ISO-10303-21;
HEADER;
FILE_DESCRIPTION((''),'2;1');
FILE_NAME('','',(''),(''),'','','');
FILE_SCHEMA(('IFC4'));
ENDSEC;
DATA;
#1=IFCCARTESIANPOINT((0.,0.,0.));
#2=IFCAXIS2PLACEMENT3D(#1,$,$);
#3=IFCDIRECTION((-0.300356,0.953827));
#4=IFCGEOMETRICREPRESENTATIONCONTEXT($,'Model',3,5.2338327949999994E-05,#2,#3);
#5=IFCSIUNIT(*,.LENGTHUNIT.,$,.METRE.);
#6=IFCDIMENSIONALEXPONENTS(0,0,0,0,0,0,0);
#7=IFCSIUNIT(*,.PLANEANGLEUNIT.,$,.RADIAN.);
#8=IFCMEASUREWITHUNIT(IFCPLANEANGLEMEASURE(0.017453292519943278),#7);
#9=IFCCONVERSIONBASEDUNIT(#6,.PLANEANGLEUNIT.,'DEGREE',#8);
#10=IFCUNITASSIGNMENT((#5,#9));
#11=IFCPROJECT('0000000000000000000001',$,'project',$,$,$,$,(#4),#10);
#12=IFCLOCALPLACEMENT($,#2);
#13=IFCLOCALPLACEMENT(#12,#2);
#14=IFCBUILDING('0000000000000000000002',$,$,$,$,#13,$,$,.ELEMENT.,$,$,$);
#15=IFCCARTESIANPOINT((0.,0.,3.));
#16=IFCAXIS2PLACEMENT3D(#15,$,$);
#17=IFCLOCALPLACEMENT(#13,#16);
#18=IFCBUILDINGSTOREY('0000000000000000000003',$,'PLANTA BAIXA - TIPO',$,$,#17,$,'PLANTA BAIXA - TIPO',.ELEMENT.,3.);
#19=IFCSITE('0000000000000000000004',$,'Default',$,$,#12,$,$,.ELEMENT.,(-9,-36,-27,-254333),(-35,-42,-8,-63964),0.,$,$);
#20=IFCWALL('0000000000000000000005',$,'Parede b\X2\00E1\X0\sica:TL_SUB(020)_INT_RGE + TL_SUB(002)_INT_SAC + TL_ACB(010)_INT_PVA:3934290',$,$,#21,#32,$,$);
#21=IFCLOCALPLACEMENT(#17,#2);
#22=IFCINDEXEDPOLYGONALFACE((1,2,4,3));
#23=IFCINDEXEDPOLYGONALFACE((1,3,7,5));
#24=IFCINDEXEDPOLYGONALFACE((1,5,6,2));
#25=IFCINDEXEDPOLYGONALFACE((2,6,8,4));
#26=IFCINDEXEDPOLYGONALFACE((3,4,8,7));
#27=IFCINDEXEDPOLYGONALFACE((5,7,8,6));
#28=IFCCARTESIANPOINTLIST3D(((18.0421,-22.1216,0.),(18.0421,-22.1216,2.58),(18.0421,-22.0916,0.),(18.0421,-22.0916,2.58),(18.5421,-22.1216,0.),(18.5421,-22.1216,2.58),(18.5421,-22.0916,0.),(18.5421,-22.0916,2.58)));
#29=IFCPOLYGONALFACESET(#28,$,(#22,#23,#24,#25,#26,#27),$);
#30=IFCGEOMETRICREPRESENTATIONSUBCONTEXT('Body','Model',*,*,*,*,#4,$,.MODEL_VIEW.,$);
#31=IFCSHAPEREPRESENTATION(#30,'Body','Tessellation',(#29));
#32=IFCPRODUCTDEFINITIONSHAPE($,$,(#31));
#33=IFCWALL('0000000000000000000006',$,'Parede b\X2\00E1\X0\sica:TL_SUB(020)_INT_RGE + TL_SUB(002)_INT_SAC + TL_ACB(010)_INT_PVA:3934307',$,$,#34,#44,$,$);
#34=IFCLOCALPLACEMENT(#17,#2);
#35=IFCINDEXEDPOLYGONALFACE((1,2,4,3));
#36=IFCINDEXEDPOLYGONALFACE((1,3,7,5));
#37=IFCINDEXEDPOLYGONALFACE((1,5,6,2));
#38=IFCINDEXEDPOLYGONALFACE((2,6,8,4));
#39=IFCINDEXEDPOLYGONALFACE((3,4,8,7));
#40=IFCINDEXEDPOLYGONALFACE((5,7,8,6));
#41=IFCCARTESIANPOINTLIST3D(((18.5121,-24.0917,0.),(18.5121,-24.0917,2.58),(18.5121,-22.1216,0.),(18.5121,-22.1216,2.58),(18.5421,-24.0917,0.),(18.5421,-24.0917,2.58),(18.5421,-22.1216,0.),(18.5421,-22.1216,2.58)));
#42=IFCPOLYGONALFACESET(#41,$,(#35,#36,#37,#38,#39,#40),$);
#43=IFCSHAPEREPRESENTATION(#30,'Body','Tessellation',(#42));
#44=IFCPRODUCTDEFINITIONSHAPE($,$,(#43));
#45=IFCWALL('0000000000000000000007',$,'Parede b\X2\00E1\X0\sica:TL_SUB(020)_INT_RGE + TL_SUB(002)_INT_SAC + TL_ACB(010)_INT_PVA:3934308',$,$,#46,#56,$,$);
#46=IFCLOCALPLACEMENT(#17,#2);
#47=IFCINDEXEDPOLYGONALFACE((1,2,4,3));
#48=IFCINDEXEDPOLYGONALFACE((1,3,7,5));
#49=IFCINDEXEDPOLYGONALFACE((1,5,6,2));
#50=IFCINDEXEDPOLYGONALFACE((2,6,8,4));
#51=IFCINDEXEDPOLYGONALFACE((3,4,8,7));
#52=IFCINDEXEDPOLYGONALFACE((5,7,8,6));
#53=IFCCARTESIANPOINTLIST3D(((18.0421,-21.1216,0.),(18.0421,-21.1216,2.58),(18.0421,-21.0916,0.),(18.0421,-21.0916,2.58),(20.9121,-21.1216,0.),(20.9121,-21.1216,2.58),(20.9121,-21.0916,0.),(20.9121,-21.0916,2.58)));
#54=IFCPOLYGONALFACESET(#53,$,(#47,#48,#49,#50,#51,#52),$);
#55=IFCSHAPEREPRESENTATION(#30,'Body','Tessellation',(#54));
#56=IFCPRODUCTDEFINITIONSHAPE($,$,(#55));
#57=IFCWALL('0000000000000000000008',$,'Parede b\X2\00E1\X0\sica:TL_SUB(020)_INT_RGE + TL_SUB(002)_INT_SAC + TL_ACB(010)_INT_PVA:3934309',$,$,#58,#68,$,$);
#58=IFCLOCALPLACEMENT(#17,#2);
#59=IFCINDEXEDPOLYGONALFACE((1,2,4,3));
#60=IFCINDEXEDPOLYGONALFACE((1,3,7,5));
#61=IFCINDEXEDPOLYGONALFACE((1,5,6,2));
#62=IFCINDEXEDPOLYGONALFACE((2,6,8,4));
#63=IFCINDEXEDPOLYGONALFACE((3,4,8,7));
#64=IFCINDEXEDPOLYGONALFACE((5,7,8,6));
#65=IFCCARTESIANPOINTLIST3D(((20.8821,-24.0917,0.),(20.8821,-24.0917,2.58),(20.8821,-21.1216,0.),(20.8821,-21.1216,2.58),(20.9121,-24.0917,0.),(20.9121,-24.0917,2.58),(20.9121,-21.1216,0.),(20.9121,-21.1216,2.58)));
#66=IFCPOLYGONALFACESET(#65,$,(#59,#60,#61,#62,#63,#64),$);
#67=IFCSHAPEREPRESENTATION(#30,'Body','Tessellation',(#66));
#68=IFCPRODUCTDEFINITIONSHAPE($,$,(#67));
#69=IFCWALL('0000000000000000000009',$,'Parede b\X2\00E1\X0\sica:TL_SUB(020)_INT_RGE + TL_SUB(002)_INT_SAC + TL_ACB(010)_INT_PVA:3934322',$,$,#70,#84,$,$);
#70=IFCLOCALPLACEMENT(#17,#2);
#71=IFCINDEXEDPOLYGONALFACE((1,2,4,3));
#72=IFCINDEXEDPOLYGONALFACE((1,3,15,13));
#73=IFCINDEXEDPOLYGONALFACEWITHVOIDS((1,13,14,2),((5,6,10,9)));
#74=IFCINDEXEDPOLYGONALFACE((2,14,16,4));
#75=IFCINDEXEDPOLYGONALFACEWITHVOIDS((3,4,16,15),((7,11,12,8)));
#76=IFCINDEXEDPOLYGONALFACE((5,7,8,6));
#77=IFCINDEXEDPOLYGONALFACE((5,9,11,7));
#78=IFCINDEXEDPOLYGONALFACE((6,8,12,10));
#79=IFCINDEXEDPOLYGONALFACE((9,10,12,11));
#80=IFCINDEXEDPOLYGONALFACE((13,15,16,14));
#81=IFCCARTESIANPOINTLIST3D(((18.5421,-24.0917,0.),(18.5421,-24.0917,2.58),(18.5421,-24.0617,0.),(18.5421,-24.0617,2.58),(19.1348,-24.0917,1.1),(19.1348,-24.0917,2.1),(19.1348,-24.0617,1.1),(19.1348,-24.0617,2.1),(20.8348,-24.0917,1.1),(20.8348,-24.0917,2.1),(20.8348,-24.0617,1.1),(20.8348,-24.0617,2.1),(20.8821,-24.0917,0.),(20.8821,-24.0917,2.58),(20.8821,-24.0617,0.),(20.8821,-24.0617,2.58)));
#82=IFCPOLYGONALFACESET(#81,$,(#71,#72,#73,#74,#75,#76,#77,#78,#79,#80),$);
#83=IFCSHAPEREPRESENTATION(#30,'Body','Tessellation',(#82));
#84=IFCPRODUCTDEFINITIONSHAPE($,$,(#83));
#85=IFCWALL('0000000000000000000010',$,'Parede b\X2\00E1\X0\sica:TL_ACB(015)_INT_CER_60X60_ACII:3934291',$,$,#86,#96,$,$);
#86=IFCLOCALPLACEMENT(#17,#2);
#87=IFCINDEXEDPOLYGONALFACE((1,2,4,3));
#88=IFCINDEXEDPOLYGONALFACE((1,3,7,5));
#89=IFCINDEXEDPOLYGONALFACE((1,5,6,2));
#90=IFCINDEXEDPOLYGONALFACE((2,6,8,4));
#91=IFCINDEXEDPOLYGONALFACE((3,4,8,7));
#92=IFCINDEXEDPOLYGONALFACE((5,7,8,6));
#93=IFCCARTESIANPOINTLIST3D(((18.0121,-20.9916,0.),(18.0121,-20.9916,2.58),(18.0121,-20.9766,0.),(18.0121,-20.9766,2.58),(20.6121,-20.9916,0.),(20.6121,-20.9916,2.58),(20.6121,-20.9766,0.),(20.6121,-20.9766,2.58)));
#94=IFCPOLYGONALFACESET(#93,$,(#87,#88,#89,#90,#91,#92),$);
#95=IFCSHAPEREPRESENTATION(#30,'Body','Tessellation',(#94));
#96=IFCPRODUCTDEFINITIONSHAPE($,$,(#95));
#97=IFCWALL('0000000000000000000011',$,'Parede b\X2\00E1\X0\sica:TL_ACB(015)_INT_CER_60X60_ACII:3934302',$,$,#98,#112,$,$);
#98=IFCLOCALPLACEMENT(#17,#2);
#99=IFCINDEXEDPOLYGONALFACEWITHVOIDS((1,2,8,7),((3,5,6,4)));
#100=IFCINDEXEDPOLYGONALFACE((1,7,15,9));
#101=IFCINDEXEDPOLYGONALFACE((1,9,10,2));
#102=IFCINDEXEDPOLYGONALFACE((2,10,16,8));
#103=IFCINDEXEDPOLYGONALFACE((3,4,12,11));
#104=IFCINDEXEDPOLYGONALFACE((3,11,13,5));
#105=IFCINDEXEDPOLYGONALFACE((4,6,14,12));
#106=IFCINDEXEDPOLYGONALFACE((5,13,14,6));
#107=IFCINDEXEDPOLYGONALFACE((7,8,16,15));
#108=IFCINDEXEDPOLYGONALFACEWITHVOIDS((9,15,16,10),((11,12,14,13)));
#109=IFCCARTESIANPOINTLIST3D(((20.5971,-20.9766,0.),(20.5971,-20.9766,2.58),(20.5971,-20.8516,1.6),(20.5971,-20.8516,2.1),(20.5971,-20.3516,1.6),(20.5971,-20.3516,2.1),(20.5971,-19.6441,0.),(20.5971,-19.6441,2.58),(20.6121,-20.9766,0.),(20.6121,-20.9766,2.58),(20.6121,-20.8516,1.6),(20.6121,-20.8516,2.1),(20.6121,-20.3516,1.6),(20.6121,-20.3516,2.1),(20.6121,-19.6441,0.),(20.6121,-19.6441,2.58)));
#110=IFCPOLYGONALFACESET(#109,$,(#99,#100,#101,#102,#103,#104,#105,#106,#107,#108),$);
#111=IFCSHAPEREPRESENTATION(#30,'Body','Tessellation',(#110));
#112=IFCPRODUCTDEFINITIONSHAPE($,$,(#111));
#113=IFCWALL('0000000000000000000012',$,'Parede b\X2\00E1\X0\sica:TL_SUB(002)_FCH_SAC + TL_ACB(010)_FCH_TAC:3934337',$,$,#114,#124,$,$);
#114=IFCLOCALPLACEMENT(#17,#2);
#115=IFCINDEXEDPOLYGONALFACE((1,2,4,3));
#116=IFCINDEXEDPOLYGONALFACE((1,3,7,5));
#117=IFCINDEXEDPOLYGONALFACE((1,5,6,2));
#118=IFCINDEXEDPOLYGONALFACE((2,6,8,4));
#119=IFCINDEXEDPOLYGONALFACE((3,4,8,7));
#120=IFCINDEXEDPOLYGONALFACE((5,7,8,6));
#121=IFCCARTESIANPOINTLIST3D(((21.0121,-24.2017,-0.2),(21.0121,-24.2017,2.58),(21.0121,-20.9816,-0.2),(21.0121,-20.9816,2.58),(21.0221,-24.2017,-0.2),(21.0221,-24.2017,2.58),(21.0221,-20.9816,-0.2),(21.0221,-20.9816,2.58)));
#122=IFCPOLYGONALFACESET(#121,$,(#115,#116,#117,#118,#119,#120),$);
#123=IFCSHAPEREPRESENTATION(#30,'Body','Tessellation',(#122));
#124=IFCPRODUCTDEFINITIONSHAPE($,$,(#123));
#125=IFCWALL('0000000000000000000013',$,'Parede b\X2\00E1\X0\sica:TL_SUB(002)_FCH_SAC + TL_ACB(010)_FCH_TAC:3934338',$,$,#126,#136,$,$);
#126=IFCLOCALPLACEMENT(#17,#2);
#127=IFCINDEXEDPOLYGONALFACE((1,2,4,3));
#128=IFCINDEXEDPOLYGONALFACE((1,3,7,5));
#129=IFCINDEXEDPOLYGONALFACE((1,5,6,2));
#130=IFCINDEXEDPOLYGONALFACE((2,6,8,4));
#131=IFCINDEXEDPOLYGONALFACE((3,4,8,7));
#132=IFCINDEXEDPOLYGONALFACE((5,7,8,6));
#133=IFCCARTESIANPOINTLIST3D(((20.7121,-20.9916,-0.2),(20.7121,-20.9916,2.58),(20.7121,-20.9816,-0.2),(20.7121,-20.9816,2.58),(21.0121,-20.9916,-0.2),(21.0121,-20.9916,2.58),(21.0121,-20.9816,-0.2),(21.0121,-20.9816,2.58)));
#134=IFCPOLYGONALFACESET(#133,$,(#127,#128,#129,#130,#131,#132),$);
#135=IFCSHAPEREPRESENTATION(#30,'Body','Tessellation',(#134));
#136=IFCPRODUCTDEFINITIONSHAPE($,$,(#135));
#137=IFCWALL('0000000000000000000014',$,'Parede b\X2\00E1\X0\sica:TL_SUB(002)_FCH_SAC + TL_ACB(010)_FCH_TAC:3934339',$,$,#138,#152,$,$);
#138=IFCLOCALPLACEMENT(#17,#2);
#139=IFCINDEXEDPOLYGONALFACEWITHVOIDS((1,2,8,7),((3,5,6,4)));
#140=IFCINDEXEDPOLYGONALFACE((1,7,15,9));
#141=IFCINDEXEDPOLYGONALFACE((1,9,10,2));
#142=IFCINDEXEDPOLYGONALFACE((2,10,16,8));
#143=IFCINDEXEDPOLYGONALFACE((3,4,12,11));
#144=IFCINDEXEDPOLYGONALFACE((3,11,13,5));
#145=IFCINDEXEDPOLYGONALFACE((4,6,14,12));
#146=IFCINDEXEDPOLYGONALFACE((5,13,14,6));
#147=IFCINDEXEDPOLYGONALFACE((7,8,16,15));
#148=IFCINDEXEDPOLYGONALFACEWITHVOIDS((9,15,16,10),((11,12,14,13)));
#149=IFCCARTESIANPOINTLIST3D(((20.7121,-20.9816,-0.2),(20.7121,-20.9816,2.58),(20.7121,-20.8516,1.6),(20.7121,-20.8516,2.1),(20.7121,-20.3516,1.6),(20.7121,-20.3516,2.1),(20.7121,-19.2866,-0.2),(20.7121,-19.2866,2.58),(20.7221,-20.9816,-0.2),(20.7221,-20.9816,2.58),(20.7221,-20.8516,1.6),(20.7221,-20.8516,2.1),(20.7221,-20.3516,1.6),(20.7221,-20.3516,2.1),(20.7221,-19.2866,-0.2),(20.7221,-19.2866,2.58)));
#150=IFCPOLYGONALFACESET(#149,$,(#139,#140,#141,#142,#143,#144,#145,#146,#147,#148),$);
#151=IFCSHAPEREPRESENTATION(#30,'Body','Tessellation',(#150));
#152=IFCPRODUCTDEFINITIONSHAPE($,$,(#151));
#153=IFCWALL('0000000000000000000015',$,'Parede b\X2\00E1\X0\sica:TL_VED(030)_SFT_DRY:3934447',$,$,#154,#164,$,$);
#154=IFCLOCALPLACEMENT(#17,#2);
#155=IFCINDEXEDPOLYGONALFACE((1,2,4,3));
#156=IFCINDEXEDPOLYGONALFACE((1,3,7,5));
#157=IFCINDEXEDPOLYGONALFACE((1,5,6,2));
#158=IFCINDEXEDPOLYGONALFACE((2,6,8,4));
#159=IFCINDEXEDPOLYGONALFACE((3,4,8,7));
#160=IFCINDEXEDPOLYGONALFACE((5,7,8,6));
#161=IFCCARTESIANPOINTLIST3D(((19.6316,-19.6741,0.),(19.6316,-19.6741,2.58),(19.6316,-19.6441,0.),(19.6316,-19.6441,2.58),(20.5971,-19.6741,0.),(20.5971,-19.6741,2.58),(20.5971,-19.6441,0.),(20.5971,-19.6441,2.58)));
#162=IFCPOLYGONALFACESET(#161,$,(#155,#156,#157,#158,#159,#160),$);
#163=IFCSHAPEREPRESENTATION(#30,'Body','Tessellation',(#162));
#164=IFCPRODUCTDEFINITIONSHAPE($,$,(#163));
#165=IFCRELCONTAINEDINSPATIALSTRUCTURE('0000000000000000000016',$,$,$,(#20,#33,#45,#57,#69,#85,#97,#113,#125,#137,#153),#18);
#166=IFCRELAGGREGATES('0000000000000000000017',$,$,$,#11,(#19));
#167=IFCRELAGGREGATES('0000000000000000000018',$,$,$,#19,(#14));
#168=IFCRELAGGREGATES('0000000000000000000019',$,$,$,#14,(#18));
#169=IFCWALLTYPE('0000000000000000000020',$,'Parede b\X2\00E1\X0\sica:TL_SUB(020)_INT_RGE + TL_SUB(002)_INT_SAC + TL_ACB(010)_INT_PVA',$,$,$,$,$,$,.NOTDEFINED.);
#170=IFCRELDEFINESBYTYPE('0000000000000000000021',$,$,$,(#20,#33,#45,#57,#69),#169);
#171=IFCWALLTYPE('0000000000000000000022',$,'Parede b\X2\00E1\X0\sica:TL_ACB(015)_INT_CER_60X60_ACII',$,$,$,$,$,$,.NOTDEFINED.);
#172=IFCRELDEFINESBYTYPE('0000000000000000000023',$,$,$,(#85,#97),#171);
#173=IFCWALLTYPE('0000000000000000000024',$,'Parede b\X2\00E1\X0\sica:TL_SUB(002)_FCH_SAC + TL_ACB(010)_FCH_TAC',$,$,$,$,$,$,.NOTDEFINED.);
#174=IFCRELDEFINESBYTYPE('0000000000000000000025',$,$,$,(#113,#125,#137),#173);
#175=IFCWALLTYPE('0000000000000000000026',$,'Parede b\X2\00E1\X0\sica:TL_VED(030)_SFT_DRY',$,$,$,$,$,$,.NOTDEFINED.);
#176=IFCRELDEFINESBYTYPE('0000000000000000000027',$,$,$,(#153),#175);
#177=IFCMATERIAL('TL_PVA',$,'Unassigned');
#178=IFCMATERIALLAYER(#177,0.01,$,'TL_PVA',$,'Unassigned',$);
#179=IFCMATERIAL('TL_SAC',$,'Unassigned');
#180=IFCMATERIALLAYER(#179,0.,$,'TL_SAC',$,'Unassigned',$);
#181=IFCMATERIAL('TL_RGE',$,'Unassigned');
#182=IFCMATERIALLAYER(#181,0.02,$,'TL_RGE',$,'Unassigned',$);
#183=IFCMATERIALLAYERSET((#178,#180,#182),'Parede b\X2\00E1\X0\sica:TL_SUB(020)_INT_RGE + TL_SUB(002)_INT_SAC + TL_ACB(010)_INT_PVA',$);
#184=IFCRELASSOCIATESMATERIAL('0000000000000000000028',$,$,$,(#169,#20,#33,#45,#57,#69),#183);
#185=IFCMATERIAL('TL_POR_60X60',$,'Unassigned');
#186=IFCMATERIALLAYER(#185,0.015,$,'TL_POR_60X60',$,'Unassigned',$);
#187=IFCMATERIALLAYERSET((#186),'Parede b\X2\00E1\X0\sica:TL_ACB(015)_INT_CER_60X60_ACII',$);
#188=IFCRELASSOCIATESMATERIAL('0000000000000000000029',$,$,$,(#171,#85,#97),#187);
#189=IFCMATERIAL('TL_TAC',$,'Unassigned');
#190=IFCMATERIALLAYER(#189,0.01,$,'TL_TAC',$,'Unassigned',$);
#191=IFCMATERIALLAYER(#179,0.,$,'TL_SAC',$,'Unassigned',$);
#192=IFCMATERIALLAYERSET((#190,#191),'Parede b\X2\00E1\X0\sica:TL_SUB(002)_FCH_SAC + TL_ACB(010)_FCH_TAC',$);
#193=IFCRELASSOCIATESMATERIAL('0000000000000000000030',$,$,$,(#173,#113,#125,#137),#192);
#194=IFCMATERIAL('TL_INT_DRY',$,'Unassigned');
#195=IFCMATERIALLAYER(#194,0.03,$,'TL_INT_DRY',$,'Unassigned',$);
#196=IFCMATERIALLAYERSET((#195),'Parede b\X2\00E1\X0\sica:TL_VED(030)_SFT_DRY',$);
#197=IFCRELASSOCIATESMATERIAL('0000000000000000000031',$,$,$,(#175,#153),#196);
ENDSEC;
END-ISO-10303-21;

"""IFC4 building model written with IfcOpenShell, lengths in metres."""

from ifc_helpers import new_model, entity, si_unit, converted_unit, direction, frame, frame_2d, origin, place, context, subcontext, project, spatial, rectangle, extrude, material, layer, layer_set, layer_usage, type_object, element, save


model = new_model("IFC4")

# Units and contexts
model_context = context("Model", 3, precision=5.2338327949999994e-05, world=origin(), true_north=direction((-0.300356, 0.953827)))
body_context = subcontext(model_context, "Body", "Model", "MODEL_VIEW")
ifc_project = project(units=[si_unit("LENGTHUNIT", "METRE"), converted_unit("PLANEANGLEUNIT", "DEGREE", entity("IfcPlaneAngleMeasure", 0.017453292519943278), si_unit("PLANEANGLEUNIT", "RADIAN"), dimensions=[0, 0, 0, 0, 0, 0, 0])], contexts=[model_context])

# Site, building, storey
site_placement = place(None, origin())
site = spatial("IfcSite", under=ifc_project, at=site_placement, Name="Default", CompositionType="ELEMENT", RefLatitude=(-9, -36, -27, -254333), RefLongitude=(-35, -42, -8, -63964), RefElevation=0.0)
building_placement = place(site_placement, origin())
building = spatial("IfcBuilding", under=site, at=building_placement, CompositionType="ELEMENT")
storey_placement = place(building_placement, frame((0.0, 0.0, 3.0)))
storey = spatial("IfcBuildingStorey", under=building, at=storey_placement, Name="PLANTA BAIXA - TIPO", LongName="PLANTA BAIXA - TIPO", CompositionType="ELEMENT", Elevation=3.0)

# Walls
ifc_material_1 = material(Name="TL_PVA", Category="Unassigned")
ifc_layer_1 = layer(ifc_material_1, 0.01, Name="TL_PVA", Category="Unassigned")
ifc_material_2 = material(Name="TL_SAC", Category="Unassigned")
ifc_layer_2 = layer(ifc_material_2, 0.0, Name="TL_SAC", Category="Unassigned")
ifc_material_3 = material(Name="TL_RGE", Category="Unassigned")
ifc_layer_3 = layer(ifc_material_3, 0.02, Name="TL_RGE", Category="Unassigned")
ifc_layer_set_1 = layer_set([ifc_layer_1, ifc_layer_2, ifc_layer_3], Name="Parede básica:TL_SUB(020)_INT_RGE + TL_SUB(002)_INT_SAC + TL_ACB(010)_INT_PVA")
ifc_layer_usage_1 = layer_usage(ifc_layer_set_1, "AXIS2", "POSITIVE", -0.015)
wall_type_1 = type_object("IfcWallType", Name="Parede básica:TL_SUB(020)_INT_RGE + TL_SUB(002)_INT_SAC + TL_ACB(010)_INT_PVA", PredefinedType="NOTDEFINED", material=ifc_layer_set_1)
wall_1_placement = place(storey_placement, frame((18.5421, -22.1066, 0.0), z_axis=(0.0, 0.0, 1.0), x_axis=(-1.0, 0.0, 0.0)))
element("IfcWall", 1, at=wall_1_placement, inside=storey, type_object=wall_type_1, material=ifc_layer_usage_1, Name="Parede básica:TL_SUB(020)_INT_RGE + TL_SUB(002)_INT_SAC + TL_ACB(010)_INT_PVA:3934290", context=body_context, shape_type="SweptSolid", body=[
    extrude(rectangle(XDim=0.5, YDim=0.03, at=frame_2d((0.25, 0.0), x_axis=(-1.0, 0.0))), origin(), (0.0, 0.0, 1.0), 2.58),
])
ifc_layer_usage_2 = layer_usage(ifc_layer_set_1, "AXIS2", "NEGATIVE", 0.015)
wall_2_placement = place(storey_placement, frame((18.5271, -22.1216, 0.0), z_axis=(0.0, 0.0, 1.0), x_axis=(0.0, -1.0, 0.0)))
element("IfcWall", 2, at=wall_2_placement, inside=storey, type_object=wall_type_1, material=ifc_layer_usage_2, Name="Parede básica:TL_SUB(020)_INT_RGE + TL_SUB(002)_INT_SAC + TL_ACB(010)_INT_PVA:3934307", context=body_context, shape_type="SweptSolid", body=[
    extrude(rectangle(XDim=1.9701, YDim=0.03, at=frame_2d((0.9851, 0.0), x_axis=(-1.0, 0.0))), origin(), (0.0, 0.0, 1.0), 2.58),
])
ifc_layer_usage_3 = layer_usage(ifc_layer_set_1, "AXIS2", "NEGATIVE", 0.015)
wall_3_placement = place(storey_placement, frame((20.9121, -21.1066, 0.0), z_axis=(0.0, 0.0, 1.0), x_axis=(-1.0, 0.0, 0.0)))
element("IfcWall", 3, at=wall_3_placement, inside=storey, type_object=wall_type_1, material=ifc_layer_usage_3, Name="Parede básica:TL_SUB(020)_INT_RGE + TL_SUB(002)_INT_SAC + TL_ACB(010)_INT_PVA:3934308", context=body_context, shape_type="SweptSolid", body=[
    extrude(rectangle(XDim=2.87, YDim=0.03, at=frame_2d((1.435, 0.0), x_axis=(-1.0, 0.0))), origin(), (0.0, 0.0, 1.0), 2.58),
])
ifc_layer_usage_4 = layer_usage(ifc_layer_set_1, "AXIS2", "NEGATIVE", 0.015)
wall_4_placement = place(storey_placement, frame((20.8971, -24.0917, 0.0), z_axis=(0.0, 0.0, 1.0), x_axis=(0.0, 1.0, 0.0)))
element("IfcWall", 4, at=wall_4_placement, inside=storey, type_object=wall_type_1, material=ifc_layer_usage_4, Name="Parede básica:TL_SUB(020)_INT_RGE + TL_SUB(002)_INT_SAC + TL_ACB(010)_INT_PVA:3934309", context=body_context, shape_type="SweptSolid", body=[
    extrude(rectangle(XDim=2.9701, YDim=0.03, at=frame_2d((1.4851, 0.0), x_axis=(-1.0, 0.0))), origin(), (0.0, 0.0, 1.0), 2.58),
])

# Wall, opening
ifc_layer_usage_5 = layer_usage(ifc_layer_set_1, "AXIS2", "NEGATIVE", 0.015)
wall_5_placement = place(storey_placement, frame((18.5421, -24.0767, 0.0)))
wall_5 = element("IfcWall", 5, at=wall_5_placement, inside=storey, type_object=wall_type_1, material=ifc_layer_usage_5, Name="Parede básica:TL_SUB(020)_INT_RGE + TL_SUB(002)_INT_SAC + TL_ACB(010)_INT_PVA:3934322", context=body_context, shape_type="SweptSolid", body=[
    extrude(rectangle(XDim=2.34, YDim=0.03, at=frame_2d((1.17, 0.0), x_axis=(-1.0, 0.0))), origin(), (0.0, 0.0, 1.0), 2.58),
])
opening_1_placement = place(wall_5_placement, frame((-18.5421, 24.0767, 1.1)))
element("IfcOpeningElement", 6, at=opening_1_placement, cuts=wall_5, PredefinedType="OPENING", context=body_context, shape_type="SweptSolid", body=[
    extrude(rectangle(XDim=1.0, YDim=1.7, at=frame_2d((0.0, 0.0), x_axis=(0.0, 1.0))), frame((19.9848, -25.6157, 0.5), z_axis=(0.0, 1.0, 0.0), x_axis=(1.0, 0.0, 0.0)), (0.0, 0.0, 1.0), 3.048),
])

# Wall
ifc_material_4 = material(Name="TL_POR_60X60", Category="Unassigned")
ifc_layer_4 = layer(ifc_material_4, 0.015, Name="TL_POR_60X60", Category="Unassigned")
ifc_layer_set_2 = layer_set([ifc_layer_4], Name="Parede básica:TL_ACB(015)_INT_CER_60X60_ACII")
ifc_layer_usage_6 = layer_usage(ifc_layer_set_2, "AXIS2", "POSITIVE", -0.0075)
wall_type_2 = type_object("IfcWallType", Name="Parede básica:TL_ACB(015)_INT_CER_60X60_ACII", PredefinedType="NOTDEFINED", material=ifc_layer_set_2)
wall_6_placement = place(storey_placement, frame((20.6121, -20.9841, 0.0), z_axis=(0.0, 0.0, 1.0), x_axis=(-1.0, 0.0, 0.0)))
element("IfcWall", 7, at=wall_6_placement, inside=storey, type_object=wall_type_2, material=ifc_layer_usage_6, Name="Parede básica:TL_ACB(015)_INT_CER_60X60_ACII:3934291", context=body_context, shape_type="SweptSolid", body=[
    extrude(rectangle(XDim=2.6, YDim=0.015, at=frame_2d((1.3, 0.0), x_axis=(-1.0, 0.0))), origin(), (0.0, 0.0, 1.0), 2.58),
])

# Wall, opening
ifc_layer_usage_7 = layer_usage(ifc_layer_set_2, "AXIS2", "NEGATIVE", 0.0075)
wall_7_placement = place(storey_placement, frame((20.6046, -20.9766, 0.0), z_axis=(0.0, 0.0, 1.0), x_axis=(0.0, 1.0, 0.0)))
wall_7 = element("IfcWall", 8, at=wall_7_placement, inside=storey, type_object=wall_type_2, material=ifc_layer_usage_7, Name="Parede básica:TL_ACB(015)_INT_CER_60X60_ACII:3934302", context=body_context, shape_type="SweptSolid", body=[
    extrude(rectangle(XDim=1.3325, YDim=0.015, at=frame_2d((0.6662, 0.0), x_axis=(-1.0, 0.0))), origin(), (0.0, 0.0, 1.0), 2.58),
])
opening_2_placement = place(wall_7_placement, frame((20.9766, 20.6046, 1.6)))
element("IfcOpeningElement", 9, at=opening_2_placement, cuts=wall_7, PredefinedType="OPENING", context=body_context, shape_type="SweptSolid", body=[
    extrude(rectangle(XDim=0.5, YDim=0.5, at=frame_2d((0.0, 0.0), x_axis=(1.0, 0.0))), frame((-20.6016, -22.2361, 0.25), z_axis=(0.0, 1.0, 0.0), x_axis=(0.0, 0.0, 1.0)), (0.0, 0.0, 1.0), 3.048),
])

# Walls
ifc_material_5 = material(Name="TL_TAC", Category="Unassigned")
ifc_layer_5 = layer(ifc_material_5, 0.01, Name="TL_TAC", Category="Unassigned")
ifc_layer_6 = layer(ifc_material_2, 0.0, Name="TL_SAC", Category="Unassigned")
ifc_layer_set_3 = layer_set([ifc_layer_5, ifc_layer_6], Name="Parede básica:TL_SUB(002)_FCH_SAC + TL_ACB(010)_FCH_TAC")
ifc_layer_usage_8 = layer_usage(ifc_layer_set_3, "AXIS2", "NEGATIVE", 0.005)
wall_type_3 = type_object("IfcWallType", Name="Parede básica:TL_SUB(002)_FCH_SAC + TL_ACB(010)_FCH_TAC", PredefinedType="NOTDEFINED", material=ifc_layer_set_3)
wall_8_placement = place(storey_placement, frame((21.0171, -24.2017, -0.2), z_axis=(0.0, 0.0, 1.0), x_axis=(0.0, 1.0, 0.0)))
element("IfcWall", 10, at=wall_8_placement, inside=storey, type_object=wall_type_3, material=ifc_layer_usage_8, Name="Parede básica:TL_SUB(002)_FCH_SAC + TL_ACB(010)_FCH_TAC:3934337", context=body_context, shape_type="SweptSolid", body=[
    extrude(rectangle(XDim=3.2201, YDim=0.01, at=frame_2d((1.6101, 0.0), x_axis=(-1.0, 0.0))), origin(), (0.0, 0.0, 1.0), 2.78),
])
ifc_layer_usage_9 = layer_usage(ifc_layer_set_3, "AXIS2", "NEGATIVE", 0.005)
wall_9_placement = place(storey_placement, frame((21.0121, -20.9866, -0.2), z_axis=(0.0, 0.0, 1.0), x_axis=(-1.0, 0.0, 0.0)))
element("IfcWall", 11, at=wall_9_placement, inside=storey, type_object=wall_type_3, material=ifc_layer_usage_9, Name="Parede básica:TL_SUB(002)_FCH_SAC + TL_ACB(010)_FCH_TAC:3934338", context=body_context, shape_type="SweptSolid", body=[
    extrude(rectangle(XDim=0.3, YDim=0.01, at=frame_2d((0.15, 0.0), x_axis=(-1.0, 0.0))), origin(), (0.0, 0.0, 1.0), 2.78),
])

# Wall, opening
ifc_layer_usage_10 = layer_usage(ifc_layer_set_3, "AXIS2", "NEGATIVE", 0.005)
wall_10_placement = place(storey_placement, frame((20.7171, -20.9816, -0.2), z_axis=(0.0, 0.0, 1.0), x_axis=(0.0, 1.0, 0.0)))
wall_10 = element("IfcWall", 12, at=wall_10_placement, inside=storey, type_object=wall_type_3, material=ifc_layer_usage_10, Name="Parede básica:TL_SUB(002)_FCH_SAC + TL_ACB(010)_FCH_TAC:3934339", context=body_context, shape_type="SweptSolid", body=[
    extrude(rectangle(XDim=1.695, YDim=0.01, at=frame_2d((0.8475, 0.0), x_axis=(-1.0, 0.0))), origin(), (0.0, 0.0, 1.0), 2.78),
])
opening_3_placement = place(wall_10_placement, frame((20.9816, 20.7171, 1.8)))
element("IfcOpeningElement", 13, at=opening_3_placement, cuts=wall_10, PredefinedType="OPENING", context=body_context, shape_type="SweptSolid", body=[
    extrude(rectangle(XDim=0.5, YDim=0.5, at=frame_2d((0.0, 0.0), x_axis=(1.0, 0.0))), frame((-20.6016, -22.2361, 0.25), z_axis=(0.0, 1.0, 0.0), x_axis=(0.0, 0.0, 1.0)), (0.0, 0.0, 1.0), 3.048),
])

# Wall
ifc_material_6 = material(Name="TL_INT_DRY", Category="Unassigned")
ifc_layer_7 = layer(ifc_material_6, 0.03, Name="TL_INT_DRY", Category="Unassigned")
ifc_layer_set_4 = layer_set([ifc_layer_7], Name="Parede básica:TL_VED(030)_SFT_DRY")
ifc_layer_usage_11 = layer_usage(ifc_layer_set_4, "AXIS2", "NEGATIVE", 0.015)
wall_type_4 = type_object("IfcWallType", Name="Parede básica:TL_VED(030)_SFT_DRY", PredefinedType="NOTDEFINED", material=ifc_layer_set_4)
wall_11_placement = place(storey_placement, frame((20.5971, -19.6591, 0.0), z_axis=(0.0, 0.0, 1.0), x_axis=(-1.0, 0.0, 0.0)))
element("IfcWall", 14, at=wall_11_placement, inside=storey, type_object=wall_type_4, material=ifc_layer_usage_11, Name="Parede básica:TL_VED(030)_SFT_DRY:3934447", context=body_context, shape_type="SweptSolid", body=[
    extrude(rectangle(XDim=0.9655, YDim=0.03, at=frame_2d((0.4828, 0.0), x_axis=(-1.0, 0.0))), origin(), (0.0, 0.0, 1.0), 2.58),
])

save(model, "model.ifc")
